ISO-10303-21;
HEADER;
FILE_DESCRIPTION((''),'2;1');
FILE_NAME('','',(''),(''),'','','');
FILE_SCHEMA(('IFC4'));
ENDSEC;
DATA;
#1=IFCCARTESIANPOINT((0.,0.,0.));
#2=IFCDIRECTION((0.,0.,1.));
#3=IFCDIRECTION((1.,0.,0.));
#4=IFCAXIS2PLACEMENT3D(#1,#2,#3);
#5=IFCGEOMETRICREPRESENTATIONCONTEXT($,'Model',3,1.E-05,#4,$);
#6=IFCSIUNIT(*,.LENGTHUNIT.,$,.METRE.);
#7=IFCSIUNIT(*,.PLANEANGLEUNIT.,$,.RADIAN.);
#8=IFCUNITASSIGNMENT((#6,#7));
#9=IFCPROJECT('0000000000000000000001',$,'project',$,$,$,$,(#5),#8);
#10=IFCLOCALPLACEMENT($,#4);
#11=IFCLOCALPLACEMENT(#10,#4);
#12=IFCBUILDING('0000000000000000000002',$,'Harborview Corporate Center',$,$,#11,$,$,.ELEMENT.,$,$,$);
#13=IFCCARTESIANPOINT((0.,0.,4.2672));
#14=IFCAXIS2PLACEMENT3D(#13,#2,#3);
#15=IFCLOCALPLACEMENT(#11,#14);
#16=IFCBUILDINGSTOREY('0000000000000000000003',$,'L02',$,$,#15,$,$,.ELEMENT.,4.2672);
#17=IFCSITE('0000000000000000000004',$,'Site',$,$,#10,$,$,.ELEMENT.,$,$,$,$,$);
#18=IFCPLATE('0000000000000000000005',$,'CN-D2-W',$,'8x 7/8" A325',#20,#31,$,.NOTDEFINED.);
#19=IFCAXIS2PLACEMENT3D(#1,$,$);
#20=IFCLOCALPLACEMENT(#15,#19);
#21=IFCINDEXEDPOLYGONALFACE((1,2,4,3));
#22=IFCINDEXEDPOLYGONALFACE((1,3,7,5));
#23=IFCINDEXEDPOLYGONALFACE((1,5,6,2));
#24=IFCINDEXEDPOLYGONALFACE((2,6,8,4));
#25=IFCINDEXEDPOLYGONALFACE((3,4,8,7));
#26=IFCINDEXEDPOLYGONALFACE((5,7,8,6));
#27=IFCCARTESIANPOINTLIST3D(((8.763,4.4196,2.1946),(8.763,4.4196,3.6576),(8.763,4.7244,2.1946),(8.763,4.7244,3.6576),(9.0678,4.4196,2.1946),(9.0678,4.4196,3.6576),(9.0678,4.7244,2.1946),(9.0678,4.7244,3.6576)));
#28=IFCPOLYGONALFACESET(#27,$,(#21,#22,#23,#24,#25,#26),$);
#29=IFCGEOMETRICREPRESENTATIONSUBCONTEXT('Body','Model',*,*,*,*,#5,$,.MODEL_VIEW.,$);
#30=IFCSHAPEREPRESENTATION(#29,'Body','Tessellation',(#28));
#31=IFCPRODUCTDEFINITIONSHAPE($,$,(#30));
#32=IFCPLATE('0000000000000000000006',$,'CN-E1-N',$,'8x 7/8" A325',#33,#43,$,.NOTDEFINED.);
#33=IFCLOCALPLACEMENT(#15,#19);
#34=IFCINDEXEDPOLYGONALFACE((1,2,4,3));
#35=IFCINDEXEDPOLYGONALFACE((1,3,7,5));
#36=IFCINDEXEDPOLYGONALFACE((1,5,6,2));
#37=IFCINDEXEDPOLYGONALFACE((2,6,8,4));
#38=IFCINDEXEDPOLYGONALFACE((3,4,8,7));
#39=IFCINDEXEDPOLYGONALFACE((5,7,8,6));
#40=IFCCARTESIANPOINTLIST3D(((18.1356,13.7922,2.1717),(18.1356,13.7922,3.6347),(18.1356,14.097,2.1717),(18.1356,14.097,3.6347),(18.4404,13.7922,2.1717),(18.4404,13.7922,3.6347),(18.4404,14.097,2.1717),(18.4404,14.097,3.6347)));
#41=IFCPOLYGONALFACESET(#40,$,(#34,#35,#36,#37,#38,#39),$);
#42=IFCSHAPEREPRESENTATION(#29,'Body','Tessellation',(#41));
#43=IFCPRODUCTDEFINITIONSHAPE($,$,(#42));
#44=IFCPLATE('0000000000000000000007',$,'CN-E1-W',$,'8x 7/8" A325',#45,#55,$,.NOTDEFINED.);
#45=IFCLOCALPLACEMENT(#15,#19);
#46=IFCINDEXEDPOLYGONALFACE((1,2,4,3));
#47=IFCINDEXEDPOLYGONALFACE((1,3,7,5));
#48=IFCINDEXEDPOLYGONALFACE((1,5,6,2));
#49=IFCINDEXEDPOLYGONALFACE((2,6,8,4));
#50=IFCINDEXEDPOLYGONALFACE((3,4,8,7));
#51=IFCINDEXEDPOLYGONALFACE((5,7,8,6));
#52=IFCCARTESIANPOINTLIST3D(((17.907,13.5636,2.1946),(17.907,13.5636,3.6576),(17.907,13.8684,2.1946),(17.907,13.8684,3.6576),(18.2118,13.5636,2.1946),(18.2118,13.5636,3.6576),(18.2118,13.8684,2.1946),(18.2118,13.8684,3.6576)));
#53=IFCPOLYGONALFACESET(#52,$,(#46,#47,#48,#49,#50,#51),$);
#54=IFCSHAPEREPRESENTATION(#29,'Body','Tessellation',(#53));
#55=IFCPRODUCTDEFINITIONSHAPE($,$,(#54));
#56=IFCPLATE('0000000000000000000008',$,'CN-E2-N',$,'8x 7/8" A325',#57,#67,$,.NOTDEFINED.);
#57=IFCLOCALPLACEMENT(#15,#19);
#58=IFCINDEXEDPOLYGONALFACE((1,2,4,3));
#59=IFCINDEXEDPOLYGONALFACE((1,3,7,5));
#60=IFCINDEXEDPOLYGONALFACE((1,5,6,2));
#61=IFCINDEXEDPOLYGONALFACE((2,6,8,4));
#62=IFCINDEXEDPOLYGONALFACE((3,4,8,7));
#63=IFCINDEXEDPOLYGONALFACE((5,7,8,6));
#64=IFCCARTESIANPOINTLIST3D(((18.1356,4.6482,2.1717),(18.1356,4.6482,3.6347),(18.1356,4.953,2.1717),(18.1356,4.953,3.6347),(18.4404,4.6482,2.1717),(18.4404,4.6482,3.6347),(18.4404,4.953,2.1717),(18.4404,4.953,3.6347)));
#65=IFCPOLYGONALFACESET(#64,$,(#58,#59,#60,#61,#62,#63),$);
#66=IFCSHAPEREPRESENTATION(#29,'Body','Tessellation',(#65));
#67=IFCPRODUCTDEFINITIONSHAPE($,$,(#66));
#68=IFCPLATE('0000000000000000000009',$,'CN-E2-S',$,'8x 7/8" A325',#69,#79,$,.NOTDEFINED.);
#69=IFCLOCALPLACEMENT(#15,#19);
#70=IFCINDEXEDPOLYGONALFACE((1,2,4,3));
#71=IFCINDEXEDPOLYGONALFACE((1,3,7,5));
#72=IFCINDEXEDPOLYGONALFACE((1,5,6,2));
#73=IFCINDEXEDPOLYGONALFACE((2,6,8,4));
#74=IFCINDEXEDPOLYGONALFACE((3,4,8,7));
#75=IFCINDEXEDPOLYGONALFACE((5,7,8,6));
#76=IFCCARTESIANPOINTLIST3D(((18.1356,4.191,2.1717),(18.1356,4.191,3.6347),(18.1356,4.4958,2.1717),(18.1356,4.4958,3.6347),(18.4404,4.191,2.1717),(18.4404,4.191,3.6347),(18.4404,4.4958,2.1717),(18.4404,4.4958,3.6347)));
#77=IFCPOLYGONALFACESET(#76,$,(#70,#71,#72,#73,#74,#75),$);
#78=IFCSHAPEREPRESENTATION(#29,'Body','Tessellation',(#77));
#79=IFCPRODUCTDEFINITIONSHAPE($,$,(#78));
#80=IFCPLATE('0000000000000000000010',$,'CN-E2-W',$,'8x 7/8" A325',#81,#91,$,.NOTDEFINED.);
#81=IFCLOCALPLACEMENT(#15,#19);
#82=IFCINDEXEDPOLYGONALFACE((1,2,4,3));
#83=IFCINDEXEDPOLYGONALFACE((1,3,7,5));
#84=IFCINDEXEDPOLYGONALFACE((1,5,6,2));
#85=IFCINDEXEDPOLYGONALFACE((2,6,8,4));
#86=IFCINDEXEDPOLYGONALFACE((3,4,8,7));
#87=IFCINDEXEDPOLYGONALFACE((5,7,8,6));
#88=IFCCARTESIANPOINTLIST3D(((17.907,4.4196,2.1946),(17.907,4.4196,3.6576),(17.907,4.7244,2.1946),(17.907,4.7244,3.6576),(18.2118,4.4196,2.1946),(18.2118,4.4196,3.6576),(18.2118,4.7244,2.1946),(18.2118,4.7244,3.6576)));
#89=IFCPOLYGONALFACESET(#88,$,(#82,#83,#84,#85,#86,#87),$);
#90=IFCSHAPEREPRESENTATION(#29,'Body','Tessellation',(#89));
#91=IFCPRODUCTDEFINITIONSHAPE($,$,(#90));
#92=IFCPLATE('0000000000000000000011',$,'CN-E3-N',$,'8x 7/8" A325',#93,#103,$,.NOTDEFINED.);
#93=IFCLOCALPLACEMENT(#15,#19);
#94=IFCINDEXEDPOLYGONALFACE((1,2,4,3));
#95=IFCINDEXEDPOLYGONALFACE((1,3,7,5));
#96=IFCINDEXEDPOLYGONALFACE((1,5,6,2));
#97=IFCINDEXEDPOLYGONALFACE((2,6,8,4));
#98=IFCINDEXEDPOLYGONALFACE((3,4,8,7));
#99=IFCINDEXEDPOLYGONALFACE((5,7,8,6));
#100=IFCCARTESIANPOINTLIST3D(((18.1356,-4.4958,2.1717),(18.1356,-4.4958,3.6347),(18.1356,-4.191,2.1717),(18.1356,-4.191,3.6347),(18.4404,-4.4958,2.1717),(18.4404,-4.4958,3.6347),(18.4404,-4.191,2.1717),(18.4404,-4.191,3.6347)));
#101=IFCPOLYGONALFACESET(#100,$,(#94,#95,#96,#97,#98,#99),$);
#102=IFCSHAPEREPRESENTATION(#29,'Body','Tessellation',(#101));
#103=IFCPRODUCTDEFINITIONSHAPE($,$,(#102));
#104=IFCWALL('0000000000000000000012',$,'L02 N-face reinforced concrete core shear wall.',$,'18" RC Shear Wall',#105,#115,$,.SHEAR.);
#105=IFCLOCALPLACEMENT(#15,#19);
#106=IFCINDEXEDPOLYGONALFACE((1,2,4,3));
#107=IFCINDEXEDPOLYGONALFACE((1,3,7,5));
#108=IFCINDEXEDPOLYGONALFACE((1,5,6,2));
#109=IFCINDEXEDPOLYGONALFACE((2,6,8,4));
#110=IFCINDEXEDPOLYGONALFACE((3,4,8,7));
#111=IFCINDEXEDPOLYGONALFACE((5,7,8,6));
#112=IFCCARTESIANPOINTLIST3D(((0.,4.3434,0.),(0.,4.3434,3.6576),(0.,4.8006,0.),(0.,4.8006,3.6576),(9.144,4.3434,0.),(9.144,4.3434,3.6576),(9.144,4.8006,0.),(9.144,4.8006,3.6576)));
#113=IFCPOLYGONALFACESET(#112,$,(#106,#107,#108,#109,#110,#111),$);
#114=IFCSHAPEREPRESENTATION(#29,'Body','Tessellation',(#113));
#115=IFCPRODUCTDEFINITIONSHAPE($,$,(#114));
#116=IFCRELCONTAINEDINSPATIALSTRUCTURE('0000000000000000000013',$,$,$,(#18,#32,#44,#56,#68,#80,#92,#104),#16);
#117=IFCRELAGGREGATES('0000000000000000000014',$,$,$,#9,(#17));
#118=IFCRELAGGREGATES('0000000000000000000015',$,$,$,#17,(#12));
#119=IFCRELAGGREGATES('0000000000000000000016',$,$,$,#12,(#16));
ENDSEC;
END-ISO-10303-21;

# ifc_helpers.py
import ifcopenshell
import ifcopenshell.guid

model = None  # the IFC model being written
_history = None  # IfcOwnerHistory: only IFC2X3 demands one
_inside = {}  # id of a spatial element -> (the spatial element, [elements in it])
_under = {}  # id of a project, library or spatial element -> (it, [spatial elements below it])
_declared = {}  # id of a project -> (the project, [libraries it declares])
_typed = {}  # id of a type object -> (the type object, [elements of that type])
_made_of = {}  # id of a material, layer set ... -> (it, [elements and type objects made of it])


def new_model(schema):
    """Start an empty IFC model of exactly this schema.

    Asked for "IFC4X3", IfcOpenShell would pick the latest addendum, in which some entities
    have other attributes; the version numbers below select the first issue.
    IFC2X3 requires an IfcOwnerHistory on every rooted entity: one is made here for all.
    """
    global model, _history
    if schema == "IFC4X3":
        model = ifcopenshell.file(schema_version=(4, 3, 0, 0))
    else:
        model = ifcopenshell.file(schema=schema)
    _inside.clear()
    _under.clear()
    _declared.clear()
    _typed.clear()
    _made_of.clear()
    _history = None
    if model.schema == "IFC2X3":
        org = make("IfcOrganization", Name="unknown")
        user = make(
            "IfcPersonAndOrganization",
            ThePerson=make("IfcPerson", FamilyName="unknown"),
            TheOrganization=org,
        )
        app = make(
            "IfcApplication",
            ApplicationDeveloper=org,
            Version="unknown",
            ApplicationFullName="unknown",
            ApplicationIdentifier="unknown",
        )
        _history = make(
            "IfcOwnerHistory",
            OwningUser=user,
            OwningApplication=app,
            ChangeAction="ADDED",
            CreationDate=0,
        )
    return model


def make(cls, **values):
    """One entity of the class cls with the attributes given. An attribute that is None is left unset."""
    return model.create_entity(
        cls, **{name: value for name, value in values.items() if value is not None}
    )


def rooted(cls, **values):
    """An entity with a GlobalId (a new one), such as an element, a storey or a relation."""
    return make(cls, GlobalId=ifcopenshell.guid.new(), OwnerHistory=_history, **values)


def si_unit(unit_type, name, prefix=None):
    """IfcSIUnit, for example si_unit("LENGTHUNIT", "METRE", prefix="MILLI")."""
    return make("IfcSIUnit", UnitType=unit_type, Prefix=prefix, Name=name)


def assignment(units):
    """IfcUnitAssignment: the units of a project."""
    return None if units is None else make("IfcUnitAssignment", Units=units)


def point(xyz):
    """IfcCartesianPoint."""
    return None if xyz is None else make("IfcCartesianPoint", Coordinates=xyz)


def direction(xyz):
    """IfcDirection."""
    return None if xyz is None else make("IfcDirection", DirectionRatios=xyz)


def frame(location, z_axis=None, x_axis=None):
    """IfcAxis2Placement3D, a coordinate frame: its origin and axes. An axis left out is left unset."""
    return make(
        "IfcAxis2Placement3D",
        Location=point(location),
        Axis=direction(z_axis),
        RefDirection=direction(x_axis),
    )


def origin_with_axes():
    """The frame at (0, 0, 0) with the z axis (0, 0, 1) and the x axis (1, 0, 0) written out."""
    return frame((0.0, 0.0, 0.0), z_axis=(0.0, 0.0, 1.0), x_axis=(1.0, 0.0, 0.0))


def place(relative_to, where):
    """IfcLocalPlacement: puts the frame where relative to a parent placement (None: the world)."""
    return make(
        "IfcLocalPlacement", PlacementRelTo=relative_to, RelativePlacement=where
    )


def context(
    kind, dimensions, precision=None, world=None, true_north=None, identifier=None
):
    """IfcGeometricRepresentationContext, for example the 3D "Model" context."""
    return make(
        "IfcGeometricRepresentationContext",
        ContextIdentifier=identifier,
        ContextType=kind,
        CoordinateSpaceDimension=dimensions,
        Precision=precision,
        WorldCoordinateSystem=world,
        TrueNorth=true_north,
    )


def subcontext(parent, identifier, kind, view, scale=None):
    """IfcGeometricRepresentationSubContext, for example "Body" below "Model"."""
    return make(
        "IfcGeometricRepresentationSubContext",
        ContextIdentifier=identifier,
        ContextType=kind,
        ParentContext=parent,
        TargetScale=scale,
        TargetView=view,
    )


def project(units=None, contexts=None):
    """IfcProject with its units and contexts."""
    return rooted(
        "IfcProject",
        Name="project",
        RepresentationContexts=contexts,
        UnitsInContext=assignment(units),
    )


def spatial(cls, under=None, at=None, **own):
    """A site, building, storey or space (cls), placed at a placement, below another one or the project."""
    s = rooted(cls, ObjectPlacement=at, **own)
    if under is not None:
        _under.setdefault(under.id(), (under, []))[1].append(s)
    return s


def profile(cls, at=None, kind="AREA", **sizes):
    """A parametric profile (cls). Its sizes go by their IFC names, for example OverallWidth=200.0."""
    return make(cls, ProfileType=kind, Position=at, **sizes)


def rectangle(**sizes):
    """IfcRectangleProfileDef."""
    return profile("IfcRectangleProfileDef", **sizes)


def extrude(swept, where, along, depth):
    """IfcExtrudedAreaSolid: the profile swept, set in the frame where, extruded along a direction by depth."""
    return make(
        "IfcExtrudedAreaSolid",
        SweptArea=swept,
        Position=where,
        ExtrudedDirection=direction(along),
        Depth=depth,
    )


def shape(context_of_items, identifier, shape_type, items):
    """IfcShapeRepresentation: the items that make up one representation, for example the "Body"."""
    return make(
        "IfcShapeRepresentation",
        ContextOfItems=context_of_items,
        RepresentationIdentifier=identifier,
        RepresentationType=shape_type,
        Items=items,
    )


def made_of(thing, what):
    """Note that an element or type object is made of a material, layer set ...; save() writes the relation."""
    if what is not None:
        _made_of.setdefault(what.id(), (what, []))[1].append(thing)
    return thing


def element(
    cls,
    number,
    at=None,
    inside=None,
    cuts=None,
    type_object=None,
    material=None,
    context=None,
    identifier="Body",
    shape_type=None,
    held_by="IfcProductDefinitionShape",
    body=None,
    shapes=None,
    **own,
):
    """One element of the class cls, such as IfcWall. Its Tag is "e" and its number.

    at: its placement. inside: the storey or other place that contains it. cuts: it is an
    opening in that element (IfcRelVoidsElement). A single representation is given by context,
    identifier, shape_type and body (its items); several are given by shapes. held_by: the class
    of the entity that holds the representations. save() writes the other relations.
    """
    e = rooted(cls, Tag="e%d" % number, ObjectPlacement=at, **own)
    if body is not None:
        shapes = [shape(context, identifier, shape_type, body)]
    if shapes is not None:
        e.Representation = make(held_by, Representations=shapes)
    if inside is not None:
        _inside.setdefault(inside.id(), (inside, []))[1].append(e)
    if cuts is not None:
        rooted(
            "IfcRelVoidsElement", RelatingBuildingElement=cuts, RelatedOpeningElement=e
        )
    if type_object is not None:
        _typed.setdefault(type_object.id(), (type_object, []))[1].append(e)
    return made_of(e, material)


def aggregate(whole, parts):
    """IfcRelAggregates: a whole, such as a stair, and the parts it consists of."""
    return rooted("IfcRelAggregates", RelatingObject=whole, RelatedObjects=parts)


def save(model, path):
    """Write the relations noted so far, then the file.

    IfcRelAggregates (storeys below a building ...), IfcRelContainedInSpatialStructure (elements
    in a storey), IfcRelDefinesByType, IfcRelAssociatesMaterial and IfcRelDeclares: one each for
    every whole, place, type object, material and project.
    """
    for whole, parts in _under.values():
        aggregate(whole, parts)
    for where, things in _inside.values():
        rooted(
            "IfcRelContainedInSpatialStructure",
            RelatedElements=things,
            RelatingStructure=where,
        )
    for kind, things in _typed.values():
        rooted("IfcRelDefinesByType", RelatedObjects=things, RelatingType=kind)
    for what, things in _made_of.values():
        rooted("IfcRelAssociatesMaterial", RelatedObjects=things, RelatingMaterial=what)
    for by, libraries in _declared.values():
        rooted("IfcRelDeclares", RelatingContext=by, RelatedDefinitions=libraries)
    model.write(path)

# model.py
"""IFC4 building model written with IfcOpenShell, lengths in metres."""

from ifc_helpers import new_model, si_unit, frame, origin_with_axes, place, context, subcontext, project, spatial, rectangle, extrude, element, save


model = new_model("IFC4")

# Units and contexts
model_context = context("Model", 3, precision=1e-05, world=origin_with_axes())
body_context = subcontext(model_context, "Body", "Model", "MODEL_VIEW")
ifc_project = project(units=[si_unit("LENGTHUNIT", "METRE"), si_unit("PLANEANGLEUNIT", "RADIAN")], contexts=[model_context])

# Site, building, storey
site_placement = place(None, origin_with_axes())
site = spatial("IfcSite", under=ifc_project, at=site_placement, Name="Site", CompositionType="ELEMENT")
building_placement = place(site_placement, origin_with_axes())
building = spatial("IfcBuilding", under=site, at=building_placement, Name="Harborview Corporate Center", CompositionType="ELEMENT")
storey_placement = place(building_placement, frame((0.0, 0.0, 4.2672), z_axis=(0.0, 0.0, 1.0), x_axis=(1.0, 0.0, 0.0)))
storey = spatial("IfcBuildingStorey", under=building, at=storey_placement, Name="L02", CompositionType="ELEMENT", Elevation=4.2672)

# Plates
for number, where, z_axis, x_axis, name in (
    (1, (8.9154, 4.572, 2.1946), (0.0, 0.0, 1.0), (1.0, 0.0, 0.0), "CN-D2-W"),
    (2, (18.288, 13.9446, 2.1717), (0.0, 0.0, 1.0), (1.0, 0.0, 0.0), "CN-E1-N"),
    (3, (18.0594, 13.716, 2.1946), (0.0, 0.0, 1.0), (1.0, 0.0, 0.0), "CN-E1-W"),
    (4, (18.288, 4.8006, 2.1717), (0.0, 0.0, 1.0), (1.0, 0.0, 0.0), "CN-E2-N"),
    (5, (18.288, 4.3434, 2.1717), (0.0, 0.0, 1.0), (1.0, 0.0, 0.0), "CN-E2-S"),
    (6, (18.0594, 4.572, 2.1946), (0.0, 0.0, 1.0), (1.0, 0.0, 0.0), "CN-E2-W"),
    (7, (18.288, -4.3434, 2.1717), (0.0, 0.0, 1.0), (1.0, 0.0, 0.0), "CN-E3-N"),
):
    element("IfcPlate", number, at=place(storey_placement, frame(where, z_axis=z_axis, x_axis=x_axis)), inside=storey, Name=name, ObjectType="8x 7/8\" A325", PredefinedType="NOTDEFINED", context=body_context, shape_type="SweptSolid", body=[
        extrude(rectangle(XDim=0.3048, YDim=0.3048), origin_with_axes(), (0.0, 0.0, 1.0), 1.463),
    ])

# Wall
wall_placement = place(storey_placement, frame((4.572, 4.572, 0.0), z_axis=(0.0, 0.0, 1.0), x_axis=(1.0, 0.0, 0.0)))
element("IfcWall", 8, at=wall_placement, inside=storey, Name="L02 N-face reinforced concrete core shear wall.", ObjectType="18\" RC Shear Wall", PredefinedType="SHEAR", context=body_context, shape_type="SweptSolid", body=[
    extrude(rectangle(XDim=9.144, YDim=0.4572), origin_with_axes(), (0.0, 0.0, 1.0), 3.6576),
])

save(model, "model.ifc")
